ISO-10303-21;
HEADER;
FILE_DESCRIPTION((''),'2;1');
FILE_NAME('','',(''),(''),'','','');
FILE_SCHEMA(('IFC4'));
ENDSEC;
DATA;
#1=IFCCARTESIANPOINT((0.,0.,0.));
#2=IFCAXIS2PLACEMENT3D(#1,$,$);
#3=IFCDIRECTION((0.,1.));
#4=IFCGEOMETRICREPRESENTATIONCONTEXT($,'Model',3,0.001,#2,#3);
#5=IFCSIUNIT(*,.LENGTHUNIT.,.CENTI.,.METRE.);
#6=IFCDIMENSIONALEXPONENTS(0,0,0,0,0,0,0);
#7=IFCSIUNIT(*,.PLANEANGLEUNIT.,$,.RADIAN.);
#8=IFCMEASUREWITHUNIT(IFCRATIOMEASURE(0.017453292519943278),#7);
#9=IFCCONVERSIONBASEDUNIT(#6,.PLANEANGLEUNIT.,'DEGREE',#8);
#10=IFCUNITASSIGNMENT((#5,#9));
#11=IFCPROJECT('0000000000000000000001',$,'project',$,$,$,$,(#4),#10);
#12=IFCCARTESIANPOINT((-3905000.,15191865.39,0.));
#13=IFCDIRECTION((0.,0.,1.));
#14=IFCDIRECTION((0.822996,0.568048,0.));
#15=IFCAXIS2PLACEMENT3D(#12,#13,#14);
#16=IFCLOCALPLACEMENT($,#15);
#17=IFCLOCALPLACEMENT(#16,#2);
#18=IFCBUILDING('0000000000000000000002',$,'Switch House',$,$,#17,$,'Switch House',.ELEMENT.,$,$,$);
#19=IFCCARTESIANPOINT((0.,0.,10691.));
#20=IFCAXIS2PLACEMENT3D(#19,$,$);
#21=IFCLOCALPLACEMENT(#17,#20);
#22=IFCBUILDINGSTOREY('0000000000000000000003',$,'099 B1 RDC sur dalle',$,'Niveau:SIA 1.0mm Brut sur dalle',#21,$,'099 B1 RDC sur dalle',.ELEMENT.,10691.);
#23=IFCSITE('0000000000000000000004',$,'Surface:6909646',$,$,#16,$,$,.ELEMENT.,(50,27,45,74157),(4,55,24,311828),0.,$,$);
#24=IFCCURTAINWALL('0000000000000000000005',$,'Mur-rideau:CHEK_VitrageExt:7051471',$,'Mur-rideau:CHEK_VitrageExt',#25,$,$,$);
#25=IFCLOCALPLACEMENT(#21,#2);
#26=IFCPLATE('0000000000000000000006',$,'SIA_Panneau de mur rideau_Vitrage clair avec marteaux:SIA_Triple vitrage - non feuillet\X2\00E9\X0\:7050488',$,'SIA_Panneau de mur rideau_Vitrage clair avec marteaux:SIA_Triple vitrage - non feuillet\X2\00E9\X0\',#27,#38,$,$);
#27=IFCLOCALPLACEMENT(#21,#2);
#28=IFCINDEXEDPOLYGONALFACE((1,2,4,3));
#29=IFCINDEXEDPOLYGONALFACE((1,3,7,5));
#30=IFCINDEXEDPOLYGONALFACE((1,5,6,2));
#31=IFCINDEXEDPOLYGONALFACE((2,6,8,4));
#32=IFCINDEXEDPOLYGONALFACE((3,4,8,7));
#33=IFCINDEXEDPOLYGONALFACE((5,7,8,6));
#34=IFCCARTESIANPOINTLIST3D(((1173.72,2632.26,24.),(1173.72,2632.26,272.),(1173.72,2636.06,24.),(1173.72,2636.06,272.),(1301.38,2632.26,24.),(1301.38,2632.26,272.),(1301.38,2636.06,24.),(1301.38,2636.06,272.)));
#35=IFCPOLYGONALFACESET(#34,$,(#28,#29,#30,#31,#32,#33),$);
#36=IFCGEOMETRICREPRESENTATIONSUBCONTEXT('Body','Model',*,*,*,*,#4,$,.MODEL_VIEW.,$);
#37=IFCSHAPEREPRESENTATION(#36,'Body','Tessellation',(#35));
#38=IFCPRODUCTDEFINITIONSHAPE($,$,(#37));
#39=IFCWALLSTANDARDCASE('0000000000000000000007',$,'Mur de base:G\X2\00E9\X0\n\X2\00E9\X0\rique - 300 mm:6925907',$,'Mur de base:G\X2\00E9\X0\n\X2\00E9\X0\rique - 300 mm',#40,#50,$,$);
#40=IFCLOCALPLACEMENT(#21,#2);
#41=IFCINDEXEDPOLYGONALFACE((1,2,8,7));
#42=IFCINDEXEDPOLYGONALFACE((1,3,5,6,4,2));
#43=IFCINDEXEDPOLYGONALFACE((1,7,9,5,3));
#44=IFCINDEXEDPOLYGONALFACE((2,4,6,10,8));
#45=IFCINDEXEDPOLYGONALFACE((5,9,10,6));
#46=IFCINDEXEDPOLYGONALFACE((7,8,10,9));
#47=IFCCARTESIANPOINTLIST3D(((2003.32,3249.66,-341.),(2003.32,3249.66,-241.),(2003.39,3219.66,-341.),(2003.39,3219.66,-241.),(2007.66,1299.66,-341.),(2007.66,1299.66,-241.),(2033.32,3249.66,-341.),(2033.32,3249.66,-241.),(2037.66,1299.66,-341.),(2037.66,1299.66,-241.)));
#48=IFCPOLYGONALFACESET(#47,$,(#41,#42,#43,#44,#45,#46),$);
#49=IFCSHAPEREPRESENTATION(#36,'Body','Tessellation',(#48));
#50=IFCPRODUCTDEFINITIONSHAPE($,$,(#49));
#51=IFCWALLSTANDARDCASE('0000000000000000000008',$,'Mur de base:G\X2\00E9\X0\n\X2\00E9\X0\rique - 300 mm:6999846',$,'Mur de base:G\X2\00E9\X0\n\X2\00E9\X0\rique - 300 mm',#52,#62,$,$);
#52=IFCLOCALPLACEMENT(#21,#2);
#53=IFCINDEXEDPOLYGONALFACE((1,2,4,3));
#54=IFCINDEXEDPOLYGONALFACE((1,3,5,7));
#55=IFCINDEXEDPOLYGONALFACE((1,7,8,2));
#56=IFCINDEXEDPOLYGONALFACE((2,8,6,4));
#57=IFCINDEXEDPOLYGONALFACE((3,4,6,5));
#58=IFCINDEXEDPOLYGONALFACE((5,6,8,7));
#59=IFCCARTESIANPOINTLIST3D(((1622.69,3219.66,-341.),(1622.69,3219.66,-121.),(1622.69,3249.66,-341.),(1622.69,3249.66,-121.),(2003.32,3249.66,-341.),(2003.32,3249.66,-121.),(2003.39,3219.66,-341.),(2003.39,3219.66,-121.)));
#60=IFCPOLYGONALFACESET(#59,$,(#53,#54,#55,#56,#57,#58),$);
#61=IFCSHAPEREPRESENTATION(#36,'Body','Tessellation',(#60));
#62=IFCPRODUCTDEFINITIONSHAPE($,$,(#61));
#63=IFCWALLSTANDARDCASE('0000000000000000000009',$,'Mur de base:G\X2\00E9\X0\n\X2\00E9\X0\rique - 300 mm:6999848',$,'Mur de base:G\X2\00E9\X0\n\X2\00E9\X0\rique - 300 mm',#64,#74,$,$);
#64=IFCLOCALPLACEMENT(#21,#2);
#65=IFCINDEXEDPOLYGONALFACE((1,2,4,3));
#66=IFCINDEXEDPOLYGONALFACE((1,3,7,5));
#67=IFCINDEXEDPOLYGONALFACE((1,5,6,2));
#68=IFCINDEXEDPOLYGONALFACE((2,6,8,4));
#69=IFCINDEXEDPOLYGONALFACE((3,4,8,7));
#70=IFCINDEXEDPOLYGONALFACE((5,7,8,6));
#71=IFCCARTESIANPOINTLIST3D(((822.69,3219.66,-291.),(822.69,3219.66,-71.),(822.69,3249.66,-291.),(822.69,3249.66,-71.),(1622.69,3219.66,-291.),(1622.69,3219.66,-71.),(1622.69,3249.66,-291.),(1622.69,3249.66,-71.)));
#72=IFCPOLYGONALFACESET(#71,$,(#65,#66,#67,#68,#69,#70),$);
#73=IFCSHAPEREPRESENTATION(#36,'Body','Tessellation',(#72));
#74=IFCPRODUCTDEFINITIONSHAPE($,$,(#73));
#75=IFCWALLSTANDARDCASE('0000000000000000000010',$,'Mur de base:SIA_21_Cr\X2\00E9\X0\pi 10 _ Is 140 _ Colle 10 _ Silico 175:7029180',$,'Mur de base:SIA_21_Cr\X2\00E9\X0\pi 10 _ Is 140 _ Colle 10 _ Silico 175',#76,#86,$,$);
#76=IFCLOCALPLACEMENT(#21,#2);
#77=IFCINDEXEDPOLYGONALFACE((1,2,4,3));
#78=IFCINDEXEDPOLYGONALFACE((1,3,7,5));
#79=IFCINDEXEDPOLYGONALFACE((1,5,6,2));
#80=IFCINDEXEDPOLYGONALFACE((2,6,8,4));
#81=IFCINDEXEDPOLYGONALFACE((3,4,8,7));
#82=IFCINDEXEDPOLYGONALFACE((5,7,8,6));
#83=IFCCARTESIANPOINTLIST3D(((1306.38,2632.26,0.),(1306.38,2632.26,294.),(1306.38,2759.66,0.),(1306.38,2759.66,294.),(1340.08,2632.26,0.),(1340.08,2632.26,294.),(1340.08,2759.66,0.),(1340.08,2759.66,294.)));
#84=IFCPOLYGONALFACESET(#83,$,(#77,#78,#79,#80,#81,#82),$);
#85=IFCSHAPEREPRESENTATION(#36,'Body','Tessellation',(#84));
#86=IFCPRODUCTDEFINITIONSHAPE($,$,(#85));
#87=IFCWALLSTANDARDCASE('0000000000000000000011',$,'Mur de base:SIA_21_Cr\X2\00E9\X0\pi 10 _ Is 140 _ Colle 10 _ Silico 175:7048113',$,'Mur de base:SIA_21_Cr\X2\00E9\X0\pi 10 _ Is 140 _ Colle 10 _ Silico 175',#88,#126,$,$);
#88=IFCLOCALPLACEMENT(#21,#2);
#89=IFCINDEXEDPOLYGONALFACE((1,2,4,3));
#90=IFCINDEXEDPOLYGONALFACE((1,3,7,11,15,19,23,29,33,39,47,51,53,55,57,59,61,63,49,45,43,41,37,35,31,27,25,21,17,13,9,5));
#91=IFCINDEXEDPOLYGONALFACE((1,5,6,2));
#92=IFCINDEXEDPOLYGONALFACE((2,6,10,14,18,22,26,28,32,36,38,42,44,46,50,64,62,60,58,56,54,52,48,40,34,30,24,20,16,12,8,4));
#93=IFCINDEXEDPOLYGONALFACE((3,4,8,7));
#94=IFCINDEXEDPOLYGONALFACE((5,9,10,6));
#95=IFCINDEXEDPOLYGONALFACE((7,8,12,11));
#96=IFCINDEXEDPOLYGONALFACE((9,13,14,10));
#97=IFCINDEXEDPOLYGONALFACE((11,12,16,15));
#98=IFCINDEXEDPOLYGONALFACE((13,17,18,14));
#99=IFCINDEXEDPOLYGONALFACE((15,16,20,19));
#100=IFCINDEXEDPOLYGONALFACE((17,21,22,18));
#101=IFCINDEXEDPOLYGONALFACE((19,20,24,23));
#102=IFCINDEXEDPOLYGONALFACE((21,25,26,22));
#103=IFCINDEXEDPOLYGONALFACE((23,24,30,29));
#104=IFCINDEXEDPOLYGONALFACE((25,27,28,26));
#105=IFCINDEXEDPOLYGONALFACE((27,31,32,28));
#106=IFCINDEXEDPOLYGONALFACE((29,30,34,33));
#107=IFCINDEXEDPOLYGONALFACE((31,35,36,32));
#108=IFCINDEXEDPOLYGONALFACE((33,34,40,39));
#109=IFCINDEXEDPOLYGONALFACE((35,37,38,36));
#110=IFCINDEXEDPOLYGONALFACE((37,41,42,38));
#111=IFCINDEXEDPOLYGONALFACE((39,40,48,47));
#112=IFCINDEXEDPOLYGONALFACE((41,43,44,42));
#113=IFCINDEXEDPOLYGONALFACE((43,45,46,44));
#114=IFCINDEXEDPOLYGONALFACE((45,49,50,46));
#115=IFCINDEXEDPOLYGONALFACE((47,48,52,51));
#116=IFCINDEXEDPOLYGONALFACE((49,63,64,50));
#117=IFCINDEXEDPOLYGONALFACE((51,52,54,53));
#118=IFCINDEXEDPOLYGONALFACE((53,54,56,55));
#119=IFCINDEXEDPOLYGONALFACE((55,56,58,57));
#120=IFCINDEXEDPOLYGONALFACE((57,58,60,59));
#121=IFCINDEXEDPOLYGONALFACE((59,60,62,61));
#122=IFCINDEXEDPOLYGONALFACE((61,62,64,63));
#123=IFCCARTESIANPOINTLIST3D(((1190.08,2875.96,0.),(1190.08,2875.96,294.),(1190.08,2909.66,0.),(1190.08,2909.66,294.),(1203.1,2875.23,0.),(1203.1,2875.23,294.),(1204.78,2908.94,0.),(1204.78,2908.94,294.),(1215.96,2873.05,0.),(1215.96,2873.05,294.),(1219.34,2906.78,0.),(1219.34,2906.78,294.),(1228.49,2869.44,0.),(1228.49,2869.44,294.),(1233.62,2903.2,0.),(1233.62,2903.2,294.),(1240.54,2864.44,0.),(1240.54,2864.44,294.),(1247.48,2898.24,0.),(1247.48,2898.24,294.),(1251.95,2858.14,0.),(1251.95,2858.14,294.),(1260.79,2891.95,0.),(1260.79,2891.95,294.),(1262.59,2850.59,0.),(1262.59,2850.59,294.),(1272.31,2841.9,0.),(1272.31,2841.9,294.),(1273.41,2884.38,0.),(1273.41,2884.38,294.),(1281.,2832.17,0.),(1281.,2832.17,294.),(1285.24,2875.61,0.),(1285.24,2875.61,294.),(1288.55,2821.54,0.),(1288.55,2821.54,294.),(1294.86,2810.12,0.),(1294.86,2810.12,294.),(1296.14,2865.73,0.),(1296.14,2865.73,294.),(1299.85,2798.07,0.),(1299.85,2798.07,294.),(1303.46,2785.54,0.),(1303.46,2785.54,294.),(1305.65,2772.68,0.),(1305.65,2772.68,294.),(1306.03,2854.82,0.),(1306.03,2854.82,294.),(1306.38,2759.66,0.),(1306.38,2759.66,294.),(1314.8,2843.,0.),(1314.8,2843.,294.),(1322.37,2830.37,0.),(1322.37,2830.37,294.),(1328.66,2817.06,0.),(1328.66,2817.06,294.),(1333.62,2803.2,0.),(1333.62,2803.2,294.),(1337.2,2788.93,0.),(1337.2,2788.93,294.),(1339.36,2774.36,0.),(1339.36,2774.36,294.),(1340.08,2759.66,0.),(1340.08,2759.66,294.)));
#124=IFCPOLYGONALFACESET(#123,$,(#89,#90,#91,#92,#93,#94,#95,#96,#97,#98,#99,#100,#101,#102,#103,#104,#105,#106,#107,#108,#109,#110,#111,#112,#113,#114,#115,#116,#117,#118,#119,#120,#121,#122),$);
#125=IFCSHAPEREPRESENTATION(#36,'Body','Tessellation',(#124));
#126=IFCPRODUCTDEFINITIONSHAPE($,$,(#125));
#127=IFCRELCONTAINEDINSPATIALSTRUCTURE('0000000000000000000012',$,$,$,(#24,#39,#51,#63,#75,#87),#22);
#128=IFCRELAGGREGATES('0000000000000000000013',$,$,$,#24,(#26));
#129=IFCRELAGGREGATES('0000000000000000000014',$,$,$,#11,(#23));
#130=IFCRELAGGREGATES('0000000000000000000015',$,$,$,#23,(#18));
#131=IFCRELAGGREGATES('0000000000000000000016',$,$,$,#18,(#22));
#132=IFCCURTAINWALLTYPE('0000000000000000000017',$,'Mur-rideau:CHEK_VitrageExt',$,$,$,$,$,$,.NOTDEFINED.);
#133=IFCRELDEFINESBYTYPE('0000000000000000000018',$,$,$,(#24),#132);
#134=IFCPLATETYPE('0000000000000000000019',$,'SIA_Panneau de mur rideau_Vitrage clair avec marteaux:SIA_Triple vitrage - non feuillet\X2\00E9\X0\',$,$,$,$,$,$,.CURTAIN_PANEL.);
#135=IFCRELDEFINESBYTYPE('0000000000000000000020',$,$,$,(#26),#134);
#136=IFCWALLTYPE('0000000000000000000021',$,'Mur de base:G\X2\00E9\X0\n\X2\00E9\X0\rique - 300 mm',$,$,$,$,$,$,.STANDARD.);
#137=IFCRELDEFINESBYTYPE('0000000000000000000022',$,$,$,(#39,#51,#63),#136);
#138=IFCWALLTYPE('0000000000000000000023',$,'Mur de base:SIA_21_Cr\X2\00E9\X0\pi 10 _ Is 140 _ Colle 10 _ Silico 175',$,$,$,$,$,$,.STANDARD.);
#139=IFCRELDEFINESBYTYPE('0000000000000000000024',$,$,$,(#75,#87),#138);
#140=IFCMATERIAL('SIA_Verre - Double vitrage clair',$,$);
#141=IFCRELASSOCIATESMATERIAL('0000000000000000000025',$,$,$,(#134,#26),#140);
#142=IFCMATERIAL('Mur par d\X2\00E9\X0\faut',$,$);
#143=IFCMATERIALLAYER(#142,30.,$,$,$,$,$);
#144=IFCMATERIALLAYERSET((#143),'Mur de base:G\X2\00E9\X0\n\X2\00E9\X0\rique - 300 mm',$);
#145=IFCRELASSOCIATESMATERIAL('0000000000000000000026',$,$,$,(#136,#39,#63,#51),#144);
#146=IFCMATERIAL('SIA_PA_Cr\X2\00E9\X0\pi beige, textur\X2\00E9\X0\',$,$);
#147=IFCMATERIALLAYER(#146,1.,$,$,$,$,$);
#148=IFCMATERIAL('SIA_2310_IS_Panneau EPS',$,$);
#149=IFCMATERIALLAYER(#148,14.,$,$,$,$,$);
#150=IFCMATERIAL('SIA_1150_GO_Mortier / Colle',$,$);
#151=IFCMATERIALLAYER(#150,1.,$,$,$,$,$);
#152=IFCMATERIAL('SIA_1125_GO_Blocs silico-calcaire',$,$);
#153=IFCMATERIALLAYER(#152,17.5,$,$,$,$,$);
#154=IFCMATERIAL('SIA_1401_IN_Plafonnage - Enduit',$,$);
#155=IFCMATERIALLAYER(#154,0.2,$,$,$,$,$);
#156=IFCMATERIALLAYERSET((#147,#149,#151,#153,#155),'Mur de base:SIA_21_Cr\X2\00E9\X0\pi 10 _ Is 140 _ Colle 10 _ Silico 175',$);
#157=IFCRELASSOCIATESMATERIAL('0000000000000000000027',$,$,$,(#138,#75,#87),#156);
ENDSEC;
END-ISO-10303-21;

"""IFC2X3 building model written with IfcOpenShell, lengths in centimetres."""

from ifc_helpers import new_model, entity, si_unit, converted_unit, direction, frame, frame_2d, origin, origin_2d_with_axis, place, context, subcontext, project, spatial, polyline, circle_curve, parameter, trimmed, segment, composite_curve, rectangle, outline, extrude, clip, halfspace, bounded_halfspace, source, transform, mapped, material, layer, layer_set, layer_usage, type_object, type_shapes, element, aggregate, save


model = new_model("IFC2X3")

# Units and contexts
model_context = context("Model", 3, precision=0.001, world=origin(), true_north=direction((0.0, 1.0)))
body_context = subcontext(model_context, "Body", "Model", "MODEL_VIEW")
ifc_project = project(units=[si_unit("LENGTHUNIT", "METRE", prefix="CENTI"), converted_unit("PLANEANGLEUNIT", "DEGREE", entity("IfcRatioMeasure", 0.017453292519943278), si_unit("PLANEANGLEUNIT", "RADIAN"), dimensions=[0, 0, 0, 0, 0, 0, 0])], contexts=[model_context])

# Site, building, storey
site_placement = place(None, frame((-3905000.0, 15191865.39, 0.0), z_axis=(0.0, 0.0, 1.0), x_axis=(0.822996, 0.568048, 0.0)))
site = spatial("IfcSite", under=ifc_project, at=site_placement, Name="Surface:6909646", CompositionType="ELEMENT", RefLatitude=(50, 27, 45, 74157), RefLongitude=(4, 55, 24, 311828), RefElevation=0.0)
building_placement = place(site_placement, origin())
building = spatial("IfcBuilding", under=site, at=building_placement, Name="Switch House", LongName="Switch House", CompositionType="ELEMENT")
storey_placement = place(building_placement, frame((0.0, 0.0, 10691.0)))
storey = spatial("IfcBuildingStorey", under=building, at=storey_placement, Name="099 B1 RDC sur dalle", ObjectType="Niveau:SIA 1.0mm Brut sur dalle", LongName="099 B1 RDC sur dalle", CompositionType="ELEMENT", Elevation=10691.0)

# Curtain wall
curtain_wall_type_1 = type_object("IfcCurtainWallType", Name="Mur-rideau:CHEK_VitrageExt", PredefinedType="NOTDEFINED")
curtain_wall_1_placement = place(storey_placement, frame((0.0, 0.0, -10691.0)))
curtain_wall_1 = element("IfcCurtainWall", 1, at=curtain_wall_1_placement, inside=storey, type_object=curtain_wall_type_1, Name="Mur-rideau:CHEK_VitrageExt:7051471", ObjectType="Mur-rideau:CHEK_VitrageExt")

# Plate
ifc_material_1 = material(Name="SIA_Verre - Double vitrage clair")
plate_type = type_object("IfcPlateType", Name="SIA_Panneau de mur rideau_Vitrage clair avec marteaux:SIA_Triple vitrage - non feuilleté", PredefinedType="CURTAIN_PANEL", material=ifc_material_1)
shared_shape_1 = source(origin(), body_context, "Body", "SweptSolid", [
    extrude(rectangle(XDim=127.65, YDim=3.8, at=origin_2d_with_axis()), frame((0.0, 1.9, 0.0), z_axis=(0.0, 0.0, 1.0), x_axis=(-1.0, 0.0, 0.0)), (0.0, 0.0, 1.0), 248.0),
])
type_shapes(plate_type, [shared_shape_1])
plate_placement = place(curtain_wall_1_placement, frame((1237.55, 2632.26, 10715.0)))
plate = element("IfcPlate", 2, at=plate_placement, type_object=plate_type, material=ifc_material_1, Name="SIA_Panneau de mur rideau_Vitrage clair avec marteaux:SIA_Triple vitrage - non feuilleté:7050488", ObjectType="SIA_Panneau de mur rideau_Vitrage clair avec marteaux:SIA_Triple vitrage - non feuilleté", context=body_context, shape_type="MappedRepresentation", body=[
    mapped(shared_shape_1, transform((0.0, 0.0, 0.0), scale=1.0)),
])
aggregate(curtain_wall_1, [plate])

# Walls
ifc_material_2 = material(Name="Mur par défaut")
ifc_layer_1 = layer(ifc_material_2, 30.0)
ifc_layer_set_1 = layer_set([ifc_layer_1], Name="Mur de base:Générique - 300 mm")
ifc_layer_usage_1 = layer_usage(ifc_layer_set_1, "AXIS2", "NEGATIVE", 15.0)
wall_type_1 = type_object("IfcWallType", Name="Mur de base:Générique - 300 mm", PredefinedType="STANDARD", material=ifc_layer_set_1)
wall_1_placement = place(storey_placement, frame((2018.32, 3249.7, -341.0), z_axis=(0.0, 0.0, 1.0), x_axis=(0.002225, -0.999998, 0.0)))
element("IfcWallStandardCase", 3, at=wall_1_placement, inside=storey, type_object=wall_type_1, material=ifc_layer_usage_1, Name="Mur de base:Générique - 300 mm:6925907", ObjectType="Mur de base:Générique - 300 mm", context=body_context, shape_type="SweptSolid", body=[
    extrude(outline(polyline([(1950.0, -15.0), (1950.07, 15.0), (0.07, 15.0), (0.0, -15.0), (30.0, -15.0), (1950.0, -15.0)])), origin(), (0.0, 0.0, 1.0), 100.0),
])
ifc_layer_usage_2 = layer_usage(ifc_layer_set_1, "AXIS2", "POSITIVE", -15.0)
wall_2_placement = place(storey_placement, frame((2003.39, 3234.66, -341.0), z_axis=(0.0, 0.0, 1.0), x_axis=(-1.0, 0.0, 0.0)))
element("IfcWallStandardCase", 4, at=wall_2_placement, inside=storey, type_object=wall_type_1, material=ifc_layer_usage_2, Name="Mur de base:Générique - 300 mm:6999846", ObjectType="Mur de base:Générique - 300 mm", context=body_context, shape_type="SweptSolid", body=[
    extrude(outline(polyline([(380.69, -15.0), (380.69, 15.0), (0.0, 15.0), (0.07, -15.0), (380.69, -15.0)])), origin(), (0.0, 0.0, 1.0), 220.0),
])
wall_3_placement = place(storey_placement, frame((1622.69, 3234.66, -291.0), z_axis=(0.0, 0.0, 1.0), x_axis=(-1.0, 0.0, 0.0)))
element("IfcWallStandardCase", 5, at=wall_3_placement, inside=storey, type_object=wall_type_1, material=ifc_layer_usage_1, Name="Mur de base:Générique - 300 mm:6999848", ObjectType="Mur de base:Générique - 300 mm", context=body_context, shape_type="SweptSolid", body=[
    extrude(rectangle(XDim=800.0, YDim=30.0, at=frame_2d((400.0, 0.0), x_axis=(-1.0, 0.0))), origin(), (0.0, 0.0, 1.0), 220.0),
])
ifc_material_3 = material(Name="SIA_PA_Crépi beige, texturé")
ifc_layer_2 = layer(ifc_material_3, 1.0)
ifc_material_4 = material(Name="SIA_2310_IS_Panneau EPS")
ifc_layer_3 = layer(ifc_material_4, 14.0)
ifc_material_5 = material(Name="SIA_1150_GO_Mortier / Colle")
ifc_layer_4 = layer(ifc_material_5, 1.0)
ifc_material_6 = material(Name="SIA_1125_GO_Blocs silico-calcaire")
ifc_layer_5 = layer(ifc_material_6, 17.5)
ifc_material_7 = material(Name="SIA_1401_IN_Plafonnage - Enduit")
ifc_layer_6 = layer(ifc_material_7, 0.2)
ifc_layer_set_2 = layer_set([ifc_layer_2, ifc_layer_3, ifc_layer_4, ifc_layer_5, ifc_layer_6], Name="Mur de base:SIA_21_Crépi 10 _ Is 140 _ Colle 10 _ Silico 175")
ifc_layer_usage_3 = layer_usage(ifc_layer_set_2, "AXIS2", "NEGATIVE", 16.85)
wall_type_2 = type_object("IfcWallType", Name="Mur de base:SIA_21_Crépi 10 _ Is 140 _ Colle 10 _ Silico 175", PredefinedType="STANDARD", material=ifc_layer_set_2)
wall_4_placement = place(storey_placement, frame((1323.23, 2759.66, 0.0), z_axis=(0.0, 0.0, 1.0), x_axis=(0.0, -1.0, 0.0)))
element("IfcWallStandardCase", 6, at=wall_4_placement, inside=storey, type_object=wall_type_2, material=ifc_layer_usage_3, Name="Mur de base:SIA_21_Crépi 10 _ Is 140 _ Colle 10 _ Silico 175:7029180", ObjectType="Mur de base:SIA_21_Crépi 10 _ Is 140 _ Colle 10 _ Silico 175", context=body_context, shape_type="Clipping", body=[
    clip(extrude(rectangle(XDim=127.4, YDim=33.7, at=frame_2d((63.7, 0.0), x_axis=(-1.0, 0.0))), origin(), (0.0, 0.0, 1.0), 294.0), bounded_halfspace(frame((0.0, -16.85, 294.0), z_axis=(0.0, 0.0, -1.0), x_axis=(1.0, 0.0, 0.0)), True, frame((0.0, -16.85, 294.0)), polyline([(0.0, 0.0), (127.4, 0.0), (127.4, 33.7), (0.0, 33.7), (0.0, 0.0)]))),
])
ifc_layer_usage_4 = layer_usage(ifc_layer_set_2, "AXIS2", "POSITIVE", -16.85)
wall_5_placement = place(storey_placement, frame((1190.08, 2892.81, 0.0)))
element("IfcWallStandardCase", 7, at=wall_5_placement, inside=storey, type_object=wall_type_2, material=ifc_layer_usage_4, Name="Mur de base:SIA_21_Crépi 10 _ Is 140 _ Colle 10 _ Silico 175:7048113", ObjectType="Mur de base:SIA_21_Crépi 10 _ Is 140 _ Colle 10 _ Silico 175", context=body_context, shape_type="Clipping", body=[
    clip(extrude(outline(composite_curve([segment(trimmed(circle_curve(frame_2d((0.0, -133.15), x_axis=(1.0, 0.0)), 150.0), [parameter(0.0)], [parameter(90.0)], True, "PARAMETER"), True, "CONTINUOUS"), segment(polyline([(0.0, 16.85), (0.0, -16.85)]), True, "CONTINUOUS"), segment(trimmed(circle_curve(frame_2d((0.0, -133.15), x_axis=(1.0, 0.0)), 116.3), [parameter(0.0)], [parameter(90.0)], True, "PARAMETER"), False, "CONTINUOUS"), segment(polyline([(116.3, -133.15), (150.0, -133.15)]), True, "CONTINUOUS")], self_intersect=False)), origin(), (0.0, 0.0, 1.0), 294.0), halfspace(frame((150.0, -133.15, 294.0), z_axis=(0.0, 0.0, -1.0), x_axis=(0.0, -1.0, 0.0)), True)),
])

save(model, "model.ifc")
